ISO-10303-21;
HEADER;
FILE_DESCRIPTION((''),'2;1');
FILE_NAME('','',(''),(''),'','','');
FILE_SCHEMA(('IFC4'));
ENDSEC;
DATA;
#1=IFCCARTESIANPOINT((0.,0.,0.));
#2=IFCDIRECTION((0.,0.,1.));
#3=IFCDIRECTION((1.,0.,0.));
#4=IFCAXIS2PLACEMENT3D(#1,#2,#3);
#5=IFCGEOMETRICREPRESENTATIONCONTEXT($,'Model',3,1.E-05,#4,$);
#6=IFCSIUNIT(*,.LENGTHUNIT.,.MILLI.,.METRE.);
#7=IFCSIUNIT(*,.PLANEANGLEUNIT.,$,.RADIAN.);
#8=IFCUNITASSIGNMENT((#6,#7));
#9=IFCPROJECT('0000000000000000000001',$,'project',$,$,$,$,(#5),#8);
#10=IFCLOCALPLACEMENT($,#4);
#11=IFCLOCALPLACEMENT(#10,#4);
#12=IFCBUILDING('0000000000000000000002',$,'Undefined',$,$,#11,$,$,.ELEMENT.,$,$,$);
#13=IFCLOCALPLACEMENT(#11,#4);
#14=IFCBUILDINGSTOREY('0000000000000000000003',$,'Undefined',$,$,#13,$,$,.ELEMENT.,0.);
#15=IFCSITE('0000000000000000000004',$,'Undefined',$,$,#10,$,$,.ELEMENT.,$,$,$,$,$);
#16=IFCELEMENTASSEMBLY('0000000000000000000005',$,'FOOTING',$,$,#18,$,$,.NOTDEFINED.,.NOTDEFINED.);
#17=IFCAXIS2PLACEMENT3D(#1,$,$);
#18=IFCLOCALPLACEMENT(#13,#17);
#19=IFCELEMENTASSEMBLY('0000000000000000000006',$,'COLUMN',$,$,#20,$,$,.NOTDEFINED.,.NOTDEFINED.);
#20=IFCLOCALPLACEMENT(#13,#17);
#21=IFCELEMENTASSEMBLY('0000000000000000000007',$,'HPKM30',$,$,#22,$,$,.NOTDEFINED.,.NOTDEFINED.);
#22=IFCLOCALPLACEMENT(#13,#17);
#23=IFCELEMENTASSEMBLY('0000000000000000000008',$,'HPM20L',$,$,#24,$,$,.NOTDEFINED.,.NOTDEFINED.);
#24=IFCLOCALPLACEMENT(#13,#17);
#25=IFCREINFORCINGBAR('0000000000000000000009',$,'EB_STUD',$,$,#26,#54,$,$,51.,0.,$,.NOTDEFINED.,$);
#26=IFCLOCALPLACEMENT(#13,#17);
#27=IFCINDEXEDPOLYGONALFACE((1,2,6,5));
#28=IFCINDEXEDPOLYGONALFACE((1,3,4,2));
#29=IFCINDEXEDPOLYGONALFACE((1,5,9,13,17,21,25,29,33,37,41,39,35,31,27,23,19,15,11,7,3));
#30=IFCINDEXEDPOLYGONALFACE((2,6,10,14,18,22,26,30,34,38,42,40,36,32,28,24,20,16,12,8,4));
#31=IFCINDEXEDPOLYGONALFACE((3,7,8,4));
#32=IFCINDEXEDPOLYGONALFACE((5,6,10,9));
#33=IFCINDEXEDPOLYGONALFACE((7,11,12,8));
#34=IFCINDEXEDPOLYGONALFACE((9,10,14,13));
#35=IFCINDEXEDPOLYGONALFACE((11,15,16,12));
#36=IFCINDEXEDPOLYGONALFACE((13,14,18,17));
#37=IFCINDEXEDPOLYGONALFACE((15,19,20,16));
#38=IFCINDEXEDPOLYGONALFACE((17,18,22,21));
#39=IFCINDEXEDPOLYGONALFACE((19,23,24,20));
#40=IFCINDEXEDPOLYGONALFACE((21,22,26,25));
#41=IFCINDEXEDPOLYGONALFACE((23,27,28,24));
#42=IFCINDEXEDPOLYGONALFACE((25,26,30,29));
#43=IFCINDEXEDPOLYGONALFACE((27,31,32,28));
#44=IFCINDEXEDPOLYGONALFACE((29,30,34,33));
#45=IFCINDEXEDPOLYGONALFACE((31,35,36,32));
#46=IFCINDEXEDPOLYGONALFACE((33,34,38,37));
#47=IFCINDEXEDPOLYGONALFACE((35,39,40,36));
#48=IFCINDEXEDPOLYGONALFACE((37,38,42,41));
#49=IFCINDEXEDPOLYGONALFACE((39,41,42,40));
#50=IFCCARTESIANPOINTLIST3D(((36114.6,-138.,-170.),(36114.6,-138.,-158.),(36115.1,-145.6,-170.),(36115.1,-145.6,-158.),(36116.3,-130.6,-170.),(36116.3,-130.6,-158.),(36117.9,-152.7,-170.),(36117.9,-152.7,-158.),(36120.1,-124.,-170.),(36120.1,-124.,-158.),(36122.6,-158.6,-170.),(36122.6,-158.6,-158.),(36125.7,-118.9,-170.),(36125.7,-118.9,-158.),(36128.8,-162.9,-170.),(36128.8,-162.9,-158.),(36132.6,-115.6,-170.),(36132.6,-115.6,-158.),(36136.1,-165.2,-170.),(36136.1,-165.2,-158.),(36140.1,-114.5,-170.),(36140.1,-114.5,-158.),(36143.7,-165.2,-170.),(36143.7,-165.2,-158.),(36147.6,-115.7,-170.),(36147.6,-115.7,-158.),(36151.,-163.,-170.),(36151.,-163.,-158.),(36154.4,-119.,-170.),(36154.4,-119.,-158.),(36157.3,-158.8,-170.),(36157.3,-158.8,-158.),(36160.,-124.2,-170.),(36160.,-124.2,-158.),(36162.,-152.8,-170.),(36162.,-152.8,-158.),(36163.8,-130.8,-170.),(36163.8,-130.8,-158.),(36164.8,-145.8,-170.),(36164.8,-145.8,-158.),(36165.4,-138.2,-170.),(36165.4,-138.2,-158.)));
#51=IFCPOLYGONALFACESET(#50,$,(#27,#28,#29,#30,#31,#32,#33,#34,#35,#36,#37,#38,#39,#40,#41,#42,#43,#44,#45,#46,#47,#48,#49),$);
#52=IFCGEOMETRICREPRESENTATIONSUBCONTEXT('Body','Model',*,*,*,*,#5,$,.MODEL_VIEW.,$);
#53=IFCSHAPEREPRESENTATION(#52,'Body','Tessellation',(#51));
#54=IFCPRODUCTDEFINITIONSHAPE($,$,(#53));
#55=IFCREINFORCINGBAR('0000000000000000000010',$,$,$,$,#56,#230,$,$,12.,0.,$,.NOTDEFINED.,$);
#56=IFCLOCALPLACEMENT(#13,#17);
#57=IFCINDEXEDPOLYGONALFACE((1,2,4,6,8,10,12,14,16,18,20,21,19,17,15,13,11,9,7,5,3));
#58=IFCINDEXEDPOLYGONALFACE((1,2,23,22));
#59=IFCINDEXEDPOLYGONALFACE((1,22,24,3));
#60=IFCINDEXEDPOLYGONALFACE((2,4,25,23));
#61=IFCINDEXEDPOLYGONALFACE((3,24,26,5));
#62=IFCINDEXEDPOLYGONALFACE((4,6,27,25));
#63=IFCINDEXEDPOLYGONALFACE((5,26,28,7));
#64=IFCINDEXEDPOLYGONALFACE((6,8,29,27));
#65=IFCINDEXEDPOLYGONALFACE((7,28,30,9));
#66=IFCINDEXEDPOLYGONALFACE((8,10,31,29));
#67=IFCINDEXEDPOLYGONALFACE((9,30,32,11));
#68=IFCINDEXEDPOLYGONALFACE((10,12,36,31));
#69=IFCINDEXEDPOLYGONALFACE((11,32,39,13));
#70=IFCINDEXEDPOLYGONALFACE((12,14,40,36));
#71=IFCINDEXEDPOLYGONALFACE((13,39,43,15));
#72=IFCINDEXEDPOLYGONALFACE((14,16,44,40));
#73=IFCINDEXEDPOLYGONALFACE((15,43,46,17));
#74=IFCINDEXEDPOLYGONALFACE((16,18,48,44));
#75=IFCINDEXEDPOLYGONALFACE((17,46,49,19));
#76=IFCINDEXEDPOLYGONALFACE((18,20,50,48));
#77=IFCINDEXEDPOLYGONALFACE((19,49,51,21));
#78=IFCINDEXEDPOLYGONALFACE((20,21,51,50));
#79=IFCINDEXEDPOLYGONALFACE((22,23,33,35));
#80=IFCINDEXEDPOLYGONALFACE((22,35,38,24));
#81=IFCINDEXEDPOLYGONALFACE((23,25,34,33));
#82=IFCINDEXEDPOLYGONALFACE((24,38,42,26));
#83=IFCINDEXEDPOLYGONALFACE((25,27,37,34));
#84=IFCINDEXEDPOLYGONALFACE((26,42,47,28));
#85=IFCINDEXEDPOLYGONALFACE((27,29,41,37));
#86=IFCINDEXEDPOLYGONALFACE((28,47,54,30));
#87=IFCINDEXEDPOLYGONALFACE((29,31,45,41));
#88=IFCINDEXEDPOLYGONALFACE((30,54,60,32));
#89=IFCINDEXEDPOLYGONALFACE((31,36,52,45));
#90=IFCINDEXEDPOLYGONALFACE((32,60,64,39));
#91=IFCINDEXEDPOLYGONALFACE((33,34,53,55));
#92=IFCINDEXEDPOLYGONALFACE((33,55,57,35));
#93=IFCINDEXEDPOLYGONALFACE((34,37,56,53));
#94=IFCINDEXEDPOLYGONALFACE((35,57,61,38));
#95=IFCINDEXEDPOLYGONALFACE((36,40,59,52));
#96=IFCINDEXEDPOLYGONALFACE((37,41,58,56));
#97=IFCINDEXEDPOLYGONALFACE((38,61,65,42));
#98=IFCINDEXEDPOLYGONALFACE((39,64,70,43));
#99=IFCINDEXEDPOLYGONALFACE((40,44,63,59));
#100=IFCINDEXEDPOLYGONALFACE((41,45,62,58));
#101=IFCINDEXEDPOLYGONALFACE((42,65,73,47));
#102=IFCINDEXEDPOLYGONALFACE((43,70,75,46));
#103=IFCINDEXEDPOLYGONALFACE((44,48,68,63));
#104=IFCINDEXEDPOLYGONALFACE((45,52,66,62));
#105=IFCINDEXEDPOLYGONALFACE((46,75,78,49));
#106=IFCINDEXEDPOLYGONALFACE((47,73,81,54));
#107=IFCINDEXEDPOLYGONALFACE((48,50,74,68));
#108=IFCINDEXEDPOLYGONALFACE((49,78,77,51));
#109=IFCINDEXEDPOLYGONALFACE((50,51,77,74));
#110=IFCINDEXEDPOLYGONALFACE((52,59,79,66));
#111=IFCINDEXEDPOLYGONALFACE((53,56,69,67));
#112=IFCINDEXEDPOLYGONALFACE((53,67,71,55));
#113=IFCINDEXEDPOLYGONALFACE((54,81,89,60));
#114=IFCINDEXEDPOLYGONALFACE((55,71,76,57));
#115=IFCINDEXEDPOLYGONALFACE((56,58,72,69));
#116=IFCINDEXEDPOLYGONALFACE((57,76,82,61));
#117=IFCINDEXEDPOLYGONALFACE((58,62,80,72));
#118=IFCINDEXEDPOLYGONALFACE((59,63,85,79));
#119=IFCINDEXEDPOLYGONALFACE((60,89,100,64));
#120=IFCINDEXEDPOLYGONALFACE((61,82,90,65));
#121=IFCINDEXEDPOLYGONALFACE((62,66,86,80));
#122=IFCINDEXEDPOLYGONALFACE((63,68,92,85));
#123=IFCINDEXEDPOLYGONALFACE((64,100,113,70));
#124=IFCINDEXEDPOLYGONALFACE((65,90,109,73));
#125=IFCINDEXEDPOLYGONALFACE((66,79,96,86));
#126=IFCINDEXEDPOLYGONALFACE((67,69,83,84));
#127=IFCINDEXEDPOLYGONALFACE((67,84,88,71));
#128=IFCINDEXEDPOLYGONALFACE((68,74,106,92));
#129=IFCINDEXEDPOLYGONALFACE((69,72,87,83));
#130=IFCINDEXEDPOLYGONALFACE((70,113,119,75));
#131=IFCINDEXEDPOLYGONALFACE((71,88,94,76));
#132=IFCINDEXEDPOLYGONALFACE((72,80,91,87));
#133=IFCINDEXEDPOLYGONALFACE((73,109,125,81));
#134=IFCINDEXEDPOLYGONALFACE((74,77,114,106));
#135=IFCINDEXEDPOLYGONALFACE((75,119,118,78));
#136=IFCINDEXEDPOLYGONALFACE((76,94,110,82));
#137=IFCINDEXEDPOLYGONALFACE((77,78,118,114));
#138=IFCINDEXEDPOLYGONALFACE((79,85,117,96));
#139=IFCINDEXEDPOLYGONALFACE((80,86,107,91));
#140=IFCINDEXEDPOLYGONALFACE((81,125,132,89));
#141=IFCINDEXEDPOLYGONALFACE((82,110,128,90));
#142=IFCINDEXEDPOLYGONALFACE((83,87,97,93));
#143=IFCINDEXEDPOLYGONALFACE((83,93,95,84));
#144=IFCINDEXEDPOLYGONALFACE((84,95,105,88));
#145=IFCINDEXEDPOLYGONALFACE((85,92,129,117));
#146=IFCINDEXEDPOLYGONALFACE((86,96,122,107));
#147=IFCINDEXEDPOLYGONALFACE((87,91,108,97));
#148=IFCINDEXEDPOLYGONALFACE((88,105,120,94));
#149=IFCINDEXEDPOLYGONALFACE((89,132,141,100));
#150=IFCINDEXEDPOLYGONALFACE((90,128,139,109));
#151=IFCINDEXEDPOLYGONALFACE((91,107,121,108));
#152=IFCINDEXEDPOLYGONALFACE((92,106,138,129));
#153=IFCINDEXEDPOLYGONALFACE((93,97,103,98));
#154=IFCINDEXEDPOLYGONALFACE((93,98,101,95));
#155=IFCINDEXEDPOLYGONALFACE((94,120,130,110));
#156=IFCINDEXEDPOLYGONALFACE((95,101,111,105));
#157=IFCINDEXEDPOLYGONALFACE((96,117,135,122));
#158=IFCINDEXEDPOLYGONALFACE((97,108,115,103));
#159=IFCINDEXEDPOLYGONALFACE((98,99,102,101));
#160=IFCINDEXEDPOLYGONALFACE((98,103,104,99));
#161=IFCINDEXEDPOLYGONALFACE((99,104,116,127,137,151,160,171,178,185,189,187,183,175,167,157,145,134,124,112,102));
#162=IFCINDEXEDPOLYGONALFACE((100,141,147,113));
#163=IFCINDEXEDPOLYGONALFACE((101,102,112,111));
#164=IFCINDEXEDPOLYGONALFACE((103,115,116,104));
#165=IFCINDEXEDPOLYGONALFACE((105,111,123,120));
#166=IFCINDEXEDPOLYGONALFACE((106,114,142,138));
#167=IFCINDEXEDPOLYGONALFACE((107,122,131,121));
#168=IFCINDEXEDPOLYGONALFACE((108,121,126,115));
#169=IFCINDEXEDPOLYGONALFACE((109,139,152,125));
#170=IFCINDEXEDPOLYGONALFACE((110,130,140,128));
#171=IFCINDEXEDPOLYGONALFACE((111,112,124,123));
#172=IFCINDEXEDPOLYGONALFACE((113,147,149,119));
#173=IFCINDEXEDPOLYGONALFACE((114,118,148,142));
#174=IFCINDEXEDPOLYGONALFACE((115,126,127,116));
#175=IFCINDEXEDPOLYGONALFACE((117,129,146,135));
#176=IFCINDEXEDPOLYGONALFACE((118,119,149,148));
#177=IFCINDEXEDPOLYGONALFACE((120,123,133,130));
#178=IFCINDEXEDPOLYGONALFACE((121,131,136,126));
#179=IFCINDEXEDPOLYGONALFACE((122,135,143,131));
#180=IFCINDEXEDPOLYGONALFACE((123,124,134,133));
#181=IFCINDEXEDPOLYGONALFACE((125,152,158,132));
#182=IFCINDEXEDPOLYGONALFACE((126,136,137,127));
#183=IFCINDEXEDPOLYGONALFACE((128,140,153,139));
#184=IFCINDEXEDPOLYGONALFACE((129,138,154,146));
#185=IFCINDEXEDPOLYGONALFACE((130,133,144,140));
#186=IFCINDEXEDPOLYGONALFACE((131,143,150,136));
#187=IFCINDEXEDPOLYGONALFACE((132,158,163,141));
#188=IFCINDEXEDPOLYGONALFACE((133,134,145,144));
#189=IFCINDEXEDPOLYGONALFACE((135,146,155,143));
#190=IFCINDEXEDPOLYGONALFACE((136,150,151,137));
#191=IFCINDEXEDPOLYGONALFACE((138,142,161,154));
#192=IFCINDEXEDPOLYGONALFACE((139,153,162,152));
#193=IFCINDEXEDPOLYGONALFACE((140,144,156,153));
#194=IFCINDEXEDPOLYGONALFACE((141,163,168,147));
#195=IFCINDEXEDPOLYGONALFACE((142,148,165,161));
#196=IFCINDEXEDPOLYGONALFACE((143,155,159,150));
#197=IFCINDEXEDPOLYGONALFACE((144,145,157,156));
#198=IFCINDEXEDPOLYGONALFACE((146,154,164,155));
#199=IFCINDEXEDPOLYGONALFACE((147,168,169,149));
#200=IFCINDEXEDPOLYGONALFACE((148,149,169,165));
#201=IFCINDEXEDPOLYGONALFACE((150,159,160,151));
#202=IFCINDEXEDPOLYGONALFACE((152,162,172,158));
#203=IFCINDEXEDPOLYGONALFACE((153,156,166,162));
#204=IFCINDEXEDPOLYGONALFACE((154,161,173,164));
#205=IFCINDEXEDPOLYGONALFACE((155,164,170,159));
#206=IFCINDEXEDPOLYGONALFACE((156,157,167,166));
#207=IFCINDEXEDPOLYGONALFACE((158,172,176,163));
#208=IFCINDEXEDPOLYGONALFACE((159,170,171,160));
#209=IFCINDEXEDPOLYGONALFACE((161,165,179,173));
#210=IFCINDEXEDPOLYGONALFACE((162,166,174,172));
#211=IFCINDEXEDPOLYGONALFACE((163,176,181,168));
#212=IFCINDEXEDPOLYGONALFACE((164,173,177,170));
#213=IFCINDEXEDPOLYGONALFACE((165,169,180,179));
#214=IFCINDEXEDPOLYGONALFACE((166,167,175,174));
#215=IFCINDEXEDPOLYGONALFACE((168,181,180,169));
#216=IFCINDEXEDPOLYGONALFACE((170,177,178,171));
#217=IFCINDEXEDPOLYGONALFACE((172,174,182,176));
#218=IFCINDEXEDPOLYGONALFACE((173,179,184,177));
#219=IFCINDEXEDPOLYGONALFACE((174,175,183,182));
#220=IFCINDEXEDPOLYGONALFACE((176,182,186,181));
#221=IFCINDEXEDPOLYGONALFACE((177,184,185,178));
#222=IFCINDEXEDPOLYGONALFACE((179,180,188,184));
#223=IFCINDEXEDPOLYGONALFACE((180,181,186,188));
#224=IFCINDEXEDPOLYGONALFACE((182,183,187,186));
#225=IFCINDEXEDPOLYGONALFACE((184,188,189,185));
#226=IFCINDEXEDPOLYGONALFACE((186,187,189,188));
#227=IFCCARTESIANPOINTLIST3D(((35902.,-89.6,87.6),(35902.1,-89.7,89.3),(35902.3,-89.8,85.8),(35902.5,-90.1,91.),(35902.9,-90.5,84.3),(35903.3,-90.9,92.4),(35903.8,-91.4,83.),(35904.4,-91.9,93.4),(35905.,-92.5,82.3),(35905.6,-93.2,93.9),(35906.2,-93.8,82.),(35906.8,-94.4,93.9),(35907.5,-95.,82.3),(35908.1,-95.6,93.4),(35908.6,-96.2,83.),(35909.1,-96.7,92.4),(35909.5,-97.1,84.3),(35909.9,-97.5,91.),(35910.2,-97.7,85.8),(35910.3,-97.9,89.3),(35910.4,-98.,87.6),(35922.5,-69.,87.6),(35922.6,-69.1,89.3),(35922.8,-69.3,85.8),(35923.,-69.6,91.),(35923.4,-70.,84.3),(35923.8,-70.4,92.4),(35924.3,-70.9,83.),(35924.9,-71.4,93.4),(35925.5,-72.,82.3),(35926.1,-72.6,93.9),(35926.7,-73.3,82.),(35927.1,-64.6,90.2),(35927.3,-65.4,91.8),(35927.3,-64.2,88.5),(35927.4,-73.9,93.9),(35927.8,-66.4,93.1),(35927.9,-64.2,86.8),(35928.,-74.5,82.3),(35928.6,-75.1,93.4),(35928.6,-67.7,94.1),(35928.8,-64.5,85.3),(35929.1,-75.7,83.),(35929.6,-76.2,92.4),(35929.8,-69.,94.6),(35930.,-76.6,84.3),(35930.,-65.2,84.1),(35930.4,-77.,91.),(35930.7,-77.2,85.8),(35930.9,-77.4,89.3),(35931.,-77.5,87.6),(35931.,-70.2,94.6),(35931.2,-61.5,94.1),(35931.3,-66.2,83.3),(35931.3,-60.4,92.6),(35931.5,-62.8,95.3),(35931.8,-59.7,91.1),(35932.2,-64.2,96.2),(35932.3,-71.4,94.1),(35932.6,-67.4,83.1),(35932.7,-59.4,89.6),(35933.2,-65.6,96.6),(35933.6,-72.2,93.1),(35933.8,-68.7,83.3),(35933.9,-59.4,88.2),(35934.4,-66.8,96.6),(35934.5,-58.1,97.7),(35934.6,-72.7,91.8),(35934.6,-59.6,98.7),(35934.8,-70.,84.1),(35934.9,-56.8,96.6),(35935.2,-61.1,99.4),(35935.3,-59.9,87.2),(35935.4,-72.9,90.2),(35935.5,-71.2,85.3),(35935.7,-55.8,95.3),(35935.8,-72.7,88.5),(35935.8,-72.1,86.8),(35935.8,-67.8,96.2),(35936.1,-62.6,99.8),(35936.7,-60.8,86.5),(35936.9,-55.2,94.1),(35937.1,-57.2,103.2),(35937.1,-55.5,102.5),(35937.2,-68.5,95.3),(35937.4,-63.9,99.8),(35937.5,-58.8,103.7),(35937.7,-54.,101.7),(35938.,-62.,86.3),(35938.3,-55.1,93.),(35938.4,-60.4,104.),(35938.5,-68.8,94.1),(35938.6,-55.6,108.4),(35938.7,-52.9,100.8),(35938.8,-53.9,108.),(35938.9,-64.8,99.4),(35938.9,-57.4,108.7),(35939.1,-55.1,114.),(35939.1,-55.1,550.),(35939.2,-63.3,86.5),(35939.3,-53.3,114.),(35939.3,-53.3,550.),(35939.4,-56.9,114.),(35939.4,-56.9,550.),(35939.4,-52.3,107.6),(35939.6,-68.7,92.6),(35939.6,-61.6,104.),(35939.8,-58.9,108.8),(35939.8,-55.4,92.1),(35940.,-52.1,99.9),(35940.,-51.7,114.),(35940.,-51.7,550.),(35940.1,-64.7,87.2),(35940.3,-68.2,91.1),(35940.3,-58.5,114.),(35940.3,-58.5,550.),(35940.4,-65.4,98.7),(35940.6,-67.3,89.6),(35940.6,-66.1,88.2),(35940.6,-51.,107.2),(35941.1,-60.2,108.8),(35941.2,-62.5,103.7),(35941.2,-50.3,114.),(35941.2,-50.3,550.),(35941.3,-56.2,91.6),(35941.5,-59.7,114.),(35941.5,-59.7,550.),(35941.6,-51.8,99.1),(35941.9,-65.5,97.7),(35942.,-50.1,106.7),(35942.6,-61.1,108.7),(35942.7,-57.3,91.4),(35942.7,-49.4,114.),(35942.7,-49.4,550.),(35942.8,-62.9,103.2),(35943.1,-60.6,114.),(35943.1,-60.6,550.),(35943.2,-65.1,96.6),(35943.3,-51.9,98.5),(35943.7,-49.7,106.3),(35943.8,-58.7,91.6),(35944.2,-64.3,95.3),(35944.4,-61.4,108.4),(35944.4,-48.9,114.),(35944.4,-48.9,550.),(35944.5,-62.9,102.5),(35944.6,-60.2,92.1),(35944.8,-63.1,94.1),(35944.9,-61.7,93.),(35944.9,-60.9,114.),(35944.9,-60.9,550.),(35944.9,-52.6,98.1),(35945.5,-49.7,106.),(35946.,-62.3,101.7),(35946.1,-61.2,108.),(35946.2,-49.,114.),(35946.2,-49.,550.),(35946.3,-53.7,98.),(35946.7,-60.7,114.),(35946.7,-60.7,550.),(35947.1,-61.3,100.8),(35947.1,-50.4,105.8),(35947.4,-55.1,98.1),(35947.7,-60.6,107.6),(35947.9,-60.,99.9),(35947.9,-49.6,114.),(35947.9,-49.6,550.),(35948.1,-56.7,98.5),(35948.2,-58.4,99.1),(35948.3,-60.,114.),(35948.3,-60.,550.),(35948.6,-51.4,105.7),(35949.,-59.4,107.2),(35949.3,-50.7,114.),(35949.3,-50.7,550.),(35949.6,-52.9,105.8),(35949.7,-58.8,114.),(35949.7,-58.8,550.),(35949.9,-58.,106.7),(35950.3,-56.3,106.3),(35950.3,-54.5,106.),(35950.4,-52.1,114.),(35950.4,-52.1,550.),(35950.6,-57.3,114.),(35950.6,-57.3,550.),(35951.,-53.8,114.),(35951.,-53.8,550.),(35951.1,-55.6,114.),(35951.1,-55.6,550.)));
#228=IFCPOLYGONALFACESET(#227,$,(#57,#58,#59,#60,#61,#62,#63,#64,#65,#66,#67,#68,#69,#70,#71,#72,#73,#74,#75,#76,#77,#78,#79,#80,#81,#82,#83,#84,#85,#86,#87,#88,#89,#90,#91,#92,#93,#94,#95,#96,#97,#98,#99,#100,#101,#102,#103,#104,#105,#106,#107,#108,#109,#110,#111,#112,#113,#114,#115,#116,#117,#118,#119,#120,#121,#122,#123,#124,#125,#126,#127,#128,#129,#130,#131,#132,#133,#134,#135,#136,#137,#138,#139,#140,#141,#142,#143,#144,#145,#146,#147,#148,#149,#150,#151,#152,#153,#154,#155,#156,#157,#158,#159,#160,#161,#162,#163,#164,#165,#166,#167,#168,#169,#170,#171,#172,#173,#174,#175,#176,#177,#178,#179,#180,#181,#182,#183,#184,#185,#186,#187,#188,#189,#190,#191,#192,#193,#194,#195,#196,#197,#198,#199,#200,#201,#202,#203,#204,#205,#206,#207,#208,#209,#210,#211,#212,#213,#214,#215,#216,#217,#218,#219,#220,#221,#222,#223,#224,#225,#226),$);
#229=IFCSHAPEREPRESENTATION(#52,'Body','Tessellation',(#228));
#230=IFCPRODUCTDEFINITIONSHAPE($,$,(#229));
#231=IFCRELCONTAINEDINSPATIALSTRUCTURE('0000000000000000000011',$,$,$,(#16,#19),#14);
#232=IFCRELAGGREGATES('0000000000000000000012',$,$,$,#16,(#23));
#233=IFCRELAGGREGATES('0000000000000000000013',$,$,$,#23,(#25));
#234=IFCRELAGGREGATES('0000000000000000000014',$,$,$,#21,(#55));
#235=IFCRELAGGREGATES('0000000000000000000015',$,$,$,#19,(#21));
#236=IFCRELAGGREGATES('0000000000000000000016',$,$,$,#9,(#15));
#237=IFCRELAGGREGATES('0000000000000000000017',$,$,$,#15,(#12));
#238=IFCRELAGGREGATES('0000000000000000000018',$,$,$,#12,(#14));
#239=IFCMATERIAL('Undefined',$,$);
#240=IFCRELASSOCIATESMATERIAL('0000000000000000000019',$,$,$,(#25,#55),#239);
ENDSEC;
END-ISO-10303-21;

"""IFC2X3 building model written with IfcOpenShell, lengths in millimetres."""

from ifc_helpers import new_model, entity, si_unit, frame, origin_with_axes, place, context, subcontext, project, spatial, source, transform, mapped, material, element, aggregate, save


model = new_model("IFC2X3")

# Units and contexts
model_context = context("Model", 3, precision=1e-05, world=origin_with_axes())
body_context = subcontext(model_context, "Body", "Model", "MODEL_VIEW")
ifc_project = project(units=[si_unit("LENGTHUNIT", "METRE", prefix="MILLI"), si_unit("PLANEANGLEUNIT", "RADIAN")], contexts=[model_context])

# Site, building, storey
site_placement = place(None, origin_with_axes())
site = spatial("IfcSite", under=ifc_project, at=site_placement, Name="Undefined", CompositionType="ELEMENT")
building_placement = place(site_placement, origin_with_axes())
building = spatial("IfcBuilding", under=site, at=building_placement, Name="Undefined", CompositionType="ELEMENT")
storey_placement = place(building_placement, origin_with_axes())
storey = spatial("IfcBuildingStorey", under=building, at=storey_placement, Name="Undefined", CompositionType="ELEMENT", Elevation=0.0)

# Element assembly
assembly_1_placement = place(storey_placement, origin_with_axes())
assembly_1 = element("IfcElementAssembly", 1, at=assembly_1_placement, inside=storey, Name="FOOTING", AssemblyPlace="NOTDEFINED", PredefinedType="NOTDEFINED")

# Element assemblies
assembly_2_placement = place(storey_placement, origin_with_axes())
assembly_2 = element("IfcElementAssembly", 2, at=assembly_2_placement, inside=storey, Name="COLUMN", AssemblyPlace="NOTDEFINED", PredefinedType="NOTDEFINED")
assembly_3_placement = place(assembly_2_placement, origin_with_axes())
assembly_3 = element("IfcElementAssembly", 3, at=assembly_3_placement, Name="HPKM30", AssemblyPlace="NOTDEFINED", PredefinedType="NOTDEFINED")

# Shared definitions
ifc_material_1 = material(Name="Undefined")

# Element assembly
assembly_4_placement = place(assembly_1_placement, origin_with_axes())
assembly_4 = element("IfcElementAssembly", 4, at=assembly_4_placement, Name="HPM20L", AssemblyPlace="NOTDEFINED", PredefinedType="NOTDEFINED")
aggregate(assembly_1, [assembly_4])

# Reinforcing bars
shared_shape_1 = source(origin_with_axes(), body_context, "Body", "AdvancedSweptSolid", [
    entity("IfcSweptDiskSolid", entity("IfcTrimmedCurve", entity("IfcLine", entity("IfcCartesianPoint", [0.0, 0.0, 0.0]), entity("IfcVector", entity("IfcDirection", [1.0, 0.0, 0.0]), 1.0)), [entity("IfcParameterValue", 0.0)], [entity("IfcParameterValue", 12.0)], True, "PARAMETER"), 25.5, None, 0.0, 12.0),
])
reinforcing_bar_1_placement = place(assembly_4_placement, frame((36140.0, -140.0, -158.0), z_axis=(0.003874, 0.999992, 0.0), x_axis=(0.0, 0.0, -1.0)))
reinforcing_bar_1 = element("IfcReinforcingBar", 5, at=reinforcing_bar_1_placement, material=ifc_material_1, Name="EB_STUD", BarRole="NOTDEFINED", CrossSectionArea=0.0, NominalDiameter=51.0, context=body_context, shape_type="MappedRepresentation", body=[
    mapped(shared_shape_1, transform((0.0, 0.0, 0.0))),
])
aggregate(assembly_4, [reinforcing_bar_1])
shared_shape_2 = source(origin_with_axes(), body_context, "Body", "AdvancedSweptSolid", [
    entity("IfcSweptDiskSolid", entity("IfcCompositeCurve", [entity("IfcCompositeCurveSegment", "CONTINUOUS", True, entity("IfcTrimmedCurve", entity("IfcLine", entity("IfcCartesianPoint", [0.0, 0.0, 0.0]), entity("IfcVector", entity("IfcDirection", [0.0, 0.0, -1.0]), 1.0)), [entity("IfcParameterValue", 0.0)], [entity("IfcParameterValue", 29.0)], True, "PARAMETER")), entity("IfcCompositeCurveSegment", "CONTINUOUS", True, entity("IfcTrimmedCurve", entity("IfcCircle", entity("IfcAxis2Placement3D", entity("IfcCartesianPoint", [26.0, 0.0, -29.0]), entity("IfcDirection", [0.0, -1.0, 0.0]), entity("IfcDirection", [-1.0, 0.0, 0.0])), 26.0), [entity("IfcParameterValue", 0.0)], [entity("IfcParameterValue", 1.570796)], True, "PARAMETER")), entity("IfcCompositeCurveSegment", "DISCONTINUOUS", True, entity("IfcTrimmedCurve", entity("IfcLine", entity("IfcCartesianPoint", [26.0, 0.0, -55.0]), entity("IfcVector", entity("IfcDirection", [1.0, 0.0, 0.0]), 1.0)), [entity("IfcParameterValue", 0.0)], [entity("IfcParameterValue", 436.0)], True, "PARAMETER"))], False), 6.0, None, 0.0, 466.6),
])
reinforcing_bar_2_placement = place(assembly_3_placement, frame((35945.1, -54.9, 88.0), z_axis=(-0.707107, -0.707107, 0.0), x_axis=(0.0, 0.0, 1.0)))
reinforcing_bar_2 = element("IfcReinforcingBar", 6, at=reinforcing_bar_2_placement, material=ifc_material_1, BarRole="NOTDEFINED", CrossSectionArea=0.0, NominalDiameter=12.0, context=body_context, shape_type="MappedRepresentation", body=[
    mapped(shared_shape_2, transform((0.0, 0.0, 55.0))),
])
aggregate(assembly_3, [reinforcing_bar_2])
aggregate(assembly_2, [assembly_3])

save(model, "model.ifc")
